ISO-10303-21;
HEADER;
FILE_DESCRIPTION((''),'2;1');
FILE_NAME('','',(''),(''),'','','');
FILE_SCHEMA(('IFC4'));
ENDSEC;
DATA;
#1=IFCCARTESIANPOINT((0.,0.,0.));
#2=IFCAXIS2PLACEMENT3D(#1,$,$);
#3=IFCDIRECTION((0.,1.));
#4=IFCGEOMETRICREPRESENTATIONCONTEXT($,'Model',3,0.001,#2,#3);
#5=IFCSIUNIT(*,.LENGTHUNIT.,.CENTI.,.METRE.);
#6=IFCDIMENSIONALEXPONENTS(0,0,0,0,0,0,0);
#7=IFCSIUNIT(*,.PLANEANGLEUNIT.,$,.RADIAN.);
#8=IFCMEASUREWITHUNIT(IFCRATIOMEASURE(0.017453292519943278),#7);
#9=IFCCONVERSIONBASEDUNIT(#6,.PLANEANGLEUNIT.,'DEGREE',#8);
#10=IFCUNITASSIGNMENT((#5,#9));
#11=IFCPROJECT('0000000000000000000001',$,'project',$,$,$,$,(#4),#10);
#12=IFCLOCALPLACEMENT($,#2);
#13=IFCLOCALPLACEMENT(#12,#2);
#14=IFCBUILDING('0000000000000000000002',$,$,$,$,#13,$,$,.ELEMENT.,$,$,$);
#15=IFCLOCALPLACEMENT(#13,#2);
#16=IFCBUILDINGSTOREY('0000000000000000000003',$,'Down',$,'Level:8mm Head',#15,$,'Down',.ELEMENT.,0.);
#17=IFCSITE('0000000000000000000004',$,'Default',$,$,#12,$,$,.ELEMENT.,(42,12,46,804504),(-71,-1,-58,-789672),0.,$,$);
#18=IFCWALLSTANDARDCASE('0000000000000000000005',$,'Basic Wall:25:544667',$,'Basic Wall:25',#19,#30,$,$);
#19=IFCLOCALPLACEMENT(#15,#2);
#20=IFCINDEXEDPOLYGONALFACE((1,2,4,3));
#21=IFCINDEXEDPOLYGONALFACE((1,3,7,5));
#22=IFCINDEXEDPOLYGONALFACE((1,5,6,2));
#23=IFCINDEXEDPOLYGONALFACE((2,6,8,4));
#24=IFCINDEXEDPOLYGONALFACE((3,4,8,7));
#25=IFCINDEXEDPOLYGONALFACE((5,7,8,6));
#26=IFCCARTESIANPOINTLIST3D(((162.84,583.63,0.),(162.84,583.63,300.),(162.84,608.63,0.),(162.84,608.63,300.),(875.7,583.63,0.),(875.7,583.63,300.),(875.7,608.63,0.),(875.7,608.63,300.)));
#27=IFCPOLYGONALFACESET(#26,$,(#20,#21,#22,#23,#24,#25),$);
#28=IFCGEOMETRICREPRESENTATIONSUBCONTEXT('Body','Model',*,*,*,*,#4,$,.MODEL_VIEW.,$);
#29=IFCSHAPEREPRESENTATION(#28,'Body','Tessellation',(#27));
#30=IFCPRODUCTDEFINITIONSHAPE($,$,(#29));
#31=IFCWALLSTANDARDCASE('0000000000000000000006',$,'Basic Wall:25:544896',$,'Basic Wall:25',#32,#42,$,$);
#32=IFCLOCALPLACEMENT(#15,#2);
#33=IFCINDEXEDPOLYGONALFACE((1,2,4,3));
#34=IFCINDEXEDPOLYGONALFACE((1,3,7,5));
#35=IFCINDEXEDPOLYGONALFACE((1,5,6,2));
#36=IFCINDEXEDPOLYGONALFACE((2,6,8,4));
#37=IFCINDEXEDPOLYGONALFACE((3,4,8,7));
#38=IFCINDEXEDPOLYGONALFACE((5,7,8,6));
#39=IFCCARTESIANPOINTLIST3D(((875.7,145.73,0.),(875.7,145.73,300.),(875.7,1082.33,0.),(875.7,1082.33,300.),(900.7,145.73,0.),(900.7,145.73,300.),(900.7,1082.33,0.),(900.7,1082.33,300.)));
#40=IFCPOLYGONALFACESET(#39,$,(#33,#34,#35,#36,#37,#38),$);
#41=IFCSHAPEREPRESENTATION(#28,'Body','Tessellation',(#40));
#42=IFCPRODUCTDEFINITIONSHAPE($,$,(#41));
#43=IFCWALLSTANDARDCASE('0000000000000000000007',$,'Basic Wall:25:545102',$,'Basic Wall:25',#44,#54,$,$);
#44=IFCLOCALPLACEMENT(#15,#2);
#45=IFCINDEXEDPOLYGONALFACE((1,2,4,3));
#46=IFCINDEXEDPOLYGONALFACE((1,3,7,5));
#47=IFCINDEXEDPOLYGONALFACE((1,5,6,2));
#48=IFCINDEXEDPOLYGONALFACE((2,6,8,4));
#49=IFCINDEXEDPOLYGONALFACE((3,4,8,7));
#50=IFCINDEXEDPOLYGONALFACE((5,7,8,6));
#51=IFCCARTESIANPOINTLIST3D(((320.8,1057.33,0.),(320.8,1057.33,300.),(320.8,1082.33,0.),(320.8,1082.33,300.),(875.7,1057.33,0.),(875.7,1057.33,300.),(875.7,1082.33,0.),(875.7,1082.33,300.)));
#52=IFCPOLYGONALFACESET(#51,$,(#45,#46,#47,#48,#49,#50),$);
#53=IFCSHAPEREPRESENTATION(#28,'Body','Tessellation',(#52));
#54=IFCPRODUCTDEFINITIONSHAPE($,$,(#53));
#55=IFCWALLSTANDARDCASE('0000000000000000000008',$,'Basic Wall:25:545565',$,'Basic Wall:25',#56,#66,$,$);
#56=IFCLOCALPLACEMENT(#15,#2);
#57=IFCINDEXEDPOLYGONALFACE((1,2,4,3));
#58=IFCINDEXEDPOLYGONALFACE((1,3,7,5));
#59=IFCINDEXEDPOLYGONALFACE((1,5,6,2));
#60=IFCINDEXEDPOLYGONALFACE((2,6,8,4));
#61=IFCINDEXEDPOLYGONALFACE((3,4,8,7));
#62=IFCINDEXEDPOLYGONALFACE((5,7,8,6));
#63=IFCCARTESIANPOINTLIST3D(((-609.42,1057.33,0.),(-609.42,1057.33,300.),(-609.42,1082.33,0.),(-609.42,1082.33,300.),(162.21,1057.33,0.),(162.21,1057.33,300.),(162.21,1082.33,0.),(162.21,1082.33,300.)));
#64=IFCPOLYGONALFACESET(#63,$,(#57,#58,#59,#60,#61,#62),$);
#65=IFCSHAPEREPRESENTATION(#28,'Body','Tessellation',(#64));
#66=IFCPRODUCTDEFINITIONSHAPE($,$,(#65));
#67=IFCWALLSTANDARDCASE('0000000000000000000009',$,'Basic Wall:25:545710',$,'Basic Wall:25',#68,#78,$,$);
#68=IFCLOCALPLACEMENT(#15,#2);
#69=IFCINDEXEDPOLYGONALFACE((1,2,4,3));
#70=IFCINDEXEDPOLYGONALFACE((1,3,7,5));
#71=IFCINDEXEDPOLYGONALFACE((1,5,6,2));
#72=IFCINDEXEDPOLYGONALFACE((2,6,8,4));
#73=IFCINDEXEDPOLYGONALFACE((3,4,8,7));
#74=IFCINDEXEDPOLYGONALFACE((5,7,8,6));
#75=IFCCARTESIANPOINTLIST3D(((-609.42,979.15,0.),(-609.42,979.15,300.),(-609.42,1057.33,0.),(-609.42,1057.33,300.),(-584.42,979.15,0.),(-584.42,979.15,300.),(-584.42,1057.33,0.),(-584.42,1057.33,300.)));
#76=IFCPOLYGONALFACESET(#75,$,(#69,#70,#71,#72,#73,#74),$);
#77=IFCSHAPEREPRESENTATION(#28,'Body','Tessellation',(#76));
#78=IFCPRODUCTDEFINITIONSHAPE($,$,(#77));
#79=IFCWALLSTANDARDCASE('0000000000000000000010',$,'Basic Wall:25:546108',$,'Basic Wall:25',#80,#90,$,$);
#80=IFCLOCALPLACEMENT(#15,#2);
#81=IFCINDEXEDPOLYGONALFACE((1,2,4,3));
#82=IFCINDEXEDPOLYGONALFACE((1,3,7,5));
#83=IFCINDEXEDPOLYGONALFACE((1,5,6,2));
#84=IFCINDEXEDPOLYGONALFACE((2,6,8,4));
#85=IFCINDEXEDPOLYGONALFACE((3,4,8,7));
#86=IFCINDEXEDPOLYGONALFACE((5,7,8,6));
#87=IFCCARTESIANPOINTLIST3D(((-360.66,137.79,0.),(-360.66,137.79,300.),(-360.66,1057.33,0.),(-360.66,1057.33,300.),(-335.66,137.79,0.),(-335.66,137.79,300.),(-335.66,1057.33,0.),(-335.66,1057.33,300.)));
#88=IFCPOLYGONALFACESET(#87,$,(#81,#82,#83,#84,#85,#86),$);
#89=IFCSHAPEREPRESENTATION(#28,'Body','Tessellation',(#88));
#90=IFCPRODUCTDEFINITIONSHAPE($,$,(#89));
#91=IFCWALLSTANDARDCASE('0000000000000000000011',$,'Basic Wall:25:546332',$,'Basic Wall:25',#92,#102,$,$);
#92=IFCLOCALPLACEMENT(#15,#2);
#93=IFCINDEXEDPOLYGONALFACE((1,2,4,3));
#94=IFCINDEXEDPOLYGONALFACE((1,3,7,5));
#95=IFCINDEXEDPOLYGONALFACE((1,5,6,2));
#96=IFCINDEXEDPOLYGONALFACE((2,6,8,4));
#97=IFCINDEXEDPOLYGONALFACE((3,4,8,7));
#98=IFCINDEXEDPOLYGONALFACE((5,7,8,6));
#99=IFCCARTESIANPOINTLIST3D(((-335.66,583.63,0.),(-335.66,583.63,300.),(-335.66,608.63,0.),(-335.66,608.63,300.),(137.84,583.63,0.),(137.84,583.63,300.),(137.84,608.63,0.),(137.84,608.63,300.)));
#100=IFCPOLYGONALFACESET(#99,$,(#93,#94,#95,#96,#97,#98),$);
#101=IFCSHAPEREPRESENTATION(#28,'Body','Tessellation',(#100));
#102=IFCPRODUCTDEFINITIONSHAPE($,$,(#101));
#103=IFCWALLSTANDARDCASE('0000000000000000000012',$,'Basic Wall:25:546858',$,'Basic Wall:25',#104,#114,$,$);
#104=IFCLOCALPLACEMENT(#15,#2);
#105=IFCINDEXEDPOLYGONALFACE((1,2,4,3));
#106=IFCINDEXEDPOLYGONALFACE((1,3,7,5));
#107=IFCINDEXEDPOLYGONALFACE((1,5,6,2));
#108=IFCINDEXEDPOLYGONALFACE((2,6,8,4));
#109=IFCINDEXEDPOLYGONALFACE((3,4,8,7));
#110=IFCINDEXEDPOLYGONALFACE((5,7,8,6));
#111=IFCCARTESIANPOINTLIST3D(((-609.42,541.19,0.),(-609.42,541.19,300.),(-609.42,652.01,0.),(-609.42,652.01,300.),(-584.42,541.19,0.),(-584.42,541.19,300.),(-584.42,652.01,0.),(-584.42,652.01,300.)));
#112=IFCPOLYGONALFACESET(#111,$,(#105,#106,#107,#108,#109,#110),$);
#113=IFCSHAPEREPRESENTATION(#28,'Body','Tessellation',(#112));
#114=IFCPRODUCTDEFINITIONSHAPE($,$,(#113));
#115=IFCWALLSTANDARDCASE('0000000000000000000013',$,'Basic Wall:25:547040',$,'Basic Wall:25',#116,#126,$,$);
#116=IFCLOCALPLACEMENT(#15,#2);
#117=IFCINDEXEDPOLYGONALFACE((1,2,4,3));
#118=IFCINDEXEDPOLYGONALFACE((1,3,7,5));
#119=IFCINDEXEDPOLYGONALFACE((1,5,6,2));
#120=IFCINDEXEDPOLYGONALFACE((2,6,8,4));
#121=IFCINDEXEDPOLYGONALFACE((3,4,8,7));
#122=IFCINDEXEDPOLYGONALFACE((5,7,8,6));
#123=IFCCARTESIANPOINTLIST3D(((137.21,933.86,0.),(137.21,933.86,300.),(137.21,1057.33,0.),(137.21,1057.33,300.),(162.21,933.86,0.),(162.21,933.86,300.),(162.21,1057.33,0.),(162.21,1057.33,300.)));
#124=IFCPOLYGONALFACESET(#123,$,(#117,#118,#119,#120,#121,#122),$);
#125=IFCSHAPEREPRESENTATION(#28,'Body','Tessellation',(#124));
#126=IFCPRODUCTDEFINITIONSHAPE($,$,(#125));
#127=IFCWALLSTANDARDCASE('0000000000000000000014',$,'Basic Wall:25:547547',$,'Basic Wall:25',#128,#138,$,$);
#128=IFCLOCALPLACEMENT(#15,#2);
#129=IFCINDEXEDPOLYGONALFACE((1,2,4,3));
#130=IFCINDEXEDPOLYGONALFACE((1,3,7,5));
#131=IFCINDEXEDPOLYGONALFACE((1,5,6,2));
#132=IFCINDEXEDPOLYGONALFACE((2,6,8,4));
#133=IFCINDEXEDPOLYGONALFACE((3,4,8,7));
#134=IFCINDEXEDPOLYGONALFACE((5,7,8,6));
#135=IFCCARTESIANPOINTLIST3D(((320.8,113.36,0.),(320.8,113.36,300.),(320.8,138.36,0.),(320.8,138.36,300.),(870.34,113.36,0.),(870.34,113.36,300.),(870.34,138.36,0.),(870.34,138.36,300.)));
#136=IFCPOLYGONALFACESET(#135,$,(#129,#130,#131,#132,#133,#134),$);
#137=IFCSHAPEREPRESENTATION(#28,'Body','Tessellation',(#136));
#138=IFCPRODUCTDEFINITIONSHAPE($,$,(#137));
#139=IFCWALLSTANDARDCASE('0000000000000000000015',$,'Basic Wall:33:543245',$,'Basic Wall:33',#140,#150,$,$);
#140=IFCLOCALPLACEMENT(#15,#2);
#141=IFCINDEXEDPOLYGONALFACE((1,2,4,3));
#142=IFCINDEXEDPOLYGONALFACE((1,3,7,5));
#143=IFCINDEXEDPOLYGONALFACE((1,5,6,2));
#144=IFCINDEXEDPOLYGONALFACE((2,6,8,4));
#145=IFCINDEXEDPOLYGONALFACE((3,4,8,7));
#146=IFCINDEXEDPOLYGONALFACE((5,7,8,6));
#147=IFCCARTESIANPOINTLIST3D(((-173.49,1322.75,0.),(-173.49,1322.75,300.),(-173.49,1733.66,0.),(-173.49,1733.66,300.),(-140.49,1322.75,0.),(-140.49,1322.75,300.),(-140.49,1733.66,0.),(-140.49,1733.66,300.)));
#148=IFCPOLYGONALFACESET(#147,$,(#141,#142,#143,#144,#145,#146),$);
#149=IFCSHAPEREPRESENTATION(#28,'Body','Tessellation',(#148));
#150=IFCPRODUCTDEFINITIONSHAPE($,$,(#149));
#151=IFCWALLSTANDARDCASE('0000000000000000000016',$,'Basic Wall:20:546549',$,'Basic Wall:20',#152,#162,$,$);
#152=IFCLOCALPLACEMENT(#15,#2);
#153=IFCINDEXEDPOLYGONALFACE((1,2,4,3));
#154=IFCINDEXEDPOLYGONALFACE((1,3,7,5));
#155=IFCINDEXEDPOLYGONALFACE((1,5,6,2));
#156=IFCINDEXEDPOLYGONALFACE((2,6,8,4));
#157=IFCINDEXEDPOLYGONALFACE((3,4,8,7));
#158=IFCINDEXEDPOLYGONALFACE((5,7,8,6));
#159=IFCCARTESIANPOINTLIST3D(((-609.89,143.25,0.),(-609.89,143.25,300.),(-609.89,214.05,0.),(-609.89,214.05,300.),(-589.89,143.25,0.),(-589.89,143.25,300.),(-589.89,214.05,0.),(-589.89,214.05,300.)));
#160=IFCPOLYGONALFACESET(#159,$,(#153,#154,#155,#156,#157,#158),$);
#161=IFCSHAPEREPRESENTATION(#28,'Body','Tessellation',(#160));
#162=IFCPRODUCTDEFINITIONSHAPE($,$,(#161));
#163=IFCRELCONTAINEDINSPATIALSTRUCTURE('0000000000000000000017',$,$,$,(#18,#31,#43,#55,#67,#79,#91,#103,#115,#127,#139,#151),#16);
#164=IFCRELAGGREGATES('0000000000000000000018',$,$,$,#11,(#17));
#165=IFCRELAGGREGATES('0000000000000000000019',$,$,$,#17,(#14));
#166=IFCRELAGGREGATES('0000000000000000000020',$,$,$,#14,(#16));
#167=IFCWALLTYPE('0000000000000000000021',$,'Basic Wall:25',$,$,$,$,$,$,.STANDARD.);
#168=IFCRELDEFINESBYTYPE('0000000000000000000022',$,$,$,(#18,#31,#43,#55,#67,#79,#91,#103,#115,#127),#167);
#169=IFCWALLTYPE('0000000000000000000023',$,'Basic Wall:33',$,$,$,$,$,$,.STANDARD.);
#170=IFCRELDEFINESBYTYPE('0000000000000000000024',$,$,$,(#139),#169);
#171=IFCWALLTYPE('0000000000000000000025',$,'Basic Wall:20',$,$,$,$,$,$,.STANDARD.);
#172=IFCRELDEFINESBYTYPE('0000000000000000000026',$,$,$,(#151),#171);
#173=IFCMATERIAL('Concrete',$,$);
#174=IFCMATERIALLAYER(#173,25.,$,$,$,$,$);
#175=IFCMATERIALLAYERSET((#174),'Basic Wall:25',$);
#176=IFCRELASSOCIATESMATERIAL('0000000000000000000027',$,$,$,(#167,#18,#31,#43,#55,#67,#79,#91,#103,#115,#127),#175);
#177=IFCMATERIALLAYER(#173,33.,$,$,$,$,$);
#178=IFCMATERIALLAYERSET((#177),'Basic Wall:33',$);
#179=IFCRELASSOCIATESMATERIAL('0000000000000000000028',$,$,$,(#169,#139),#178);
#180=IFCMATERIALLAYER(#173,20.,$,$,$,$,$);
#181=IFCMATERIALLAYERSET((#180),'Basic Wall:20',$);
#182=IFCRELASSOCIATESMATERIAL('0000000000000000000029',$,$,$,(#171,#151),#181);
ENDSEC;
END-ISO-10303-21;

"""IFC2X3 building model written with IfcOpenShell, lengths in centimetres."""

from ifc_helpers import new_model, entity, si_unit, converted_unit, direction, frame, frame_2d, origin, place, context, subcontext, project, spatial, polyline, rectangle, extrude, clip, bounded_halfspace, material, layer, layer_set, layer_usage, type_object, element, save


model = new_model("IFC2X3")

# Units and contexts
model_context = context("Model", 3, precision=0.001, world=origin(), true_north=direction((0.0, 1.0)))
body_context = subcontext(model_context, "Body", "Model", "MODEL_VIEW")
ifc_project = project(units=[si_unit("LENGTHUNIT", "METRE", prefix="CENTI"), converted_unit("PLANEANGLEUNIT", "DEGREE", entity("IfcRatioMeasure", 0.017453292519943278), si_unit("PLANEANGLEUNIT", "RADIAN"), dimensions=[0, 0, 0, 0, 0, 0, 0])], contexts=[model_context])

# Site, building, storey
site_placement = place(None, origin())
site = spatial("IfcSite", under=ifc_project, at=site_placement, Name="Default", CompositionType="ELEMENT", RefLatitude=(42, 12, 46, 804504), RefLongitude=(-71, -1, -58, -789672), RefElevation=0.0)
building_placement = place(site_placement, origin())
building = spatial("IfcBuilding", under=site, at=building_placement, CompositionType="ELEMENT")
storey_placement = place(building_placement, origin())
storey = spatial("IfcBuildingStorey", under=building, at=storey_placement, Name="Down", ObjectType="Level:8mm Head", LongName="Down", CompositionType="ELEMENT", Elevation=0.0)

# Shared definitions
ifc_material = material(Name="Concrete")

# Walls
ifc_layer_1 = layer(ifc_material, 25.0)
ifc_layer_set_1 = layer_set([ifc_layer_1], Name="Basic Wall:25")
wall_type_1 = type_object("IfcWallType", Name="Basic Wall:25", PredefinedType="STANDARD", material=ifc_layer_set_1)
ifc_layer_usage_1 = layer_usage(ifc_layer_set_1, "AXIS2", "NEGATIVE", 12.5)
wall_1_placement = place(storey_placement, frame((162.84, 596.13, 0.0)))
element("IfcWallStandardCase", 1, at=wall_1_placement, inside=storey, type_object=wall_type_1, material=ifc_layer_usage_1, Name="Basic Wall:25:544667", ObjectType="Basic Wall:25", context=body_context, shape_type="SweptSolid", body=[
    extrude(rectangle(XDim=712.86, YDim=25.0, at=frame_2d((356.43, 0.0), x_axis=(-1.0, 0.0))), origin(), (0.0, 0.0, 1.0), 300.0),
])
ifc_layer_usage_2 = layer_usage(ifc_layer_set_1, "AXIS2", "POSITIVE", -12.5)
wall_2_placement = place(storey_placement, frame((888.2, 145.73, 0.0), z_axis=(0.0, 0.0, 1.0), x_axis=(0.0, 1.0, 0.0)))
element("IfcWallStandardCase", 2, at=wall_2_placement, inside=storey, type_object=wall_type_1, material=ifc_layer_usage_2, Name="Basic Wall:25:544896", ObjectType="Basic Wall:25", context=body_context, shape_type="SweptSolid", body=[
    extrude(rectangle(XDim=936.61, YDim=25.0, at=frame_2d((468.3, 0.0), x_axis=(-1.0, 0.0))), origin(), (0.0, 0.0, 1.0), 300.0),
])
ifc_layer_usage_3 = layer_usage(ifc_layer_set_1, "AXIS2", "POSITIVE", -12.5)
wall_3_placement = place(storey_placement, frame((875.7, 1069.83, 0.0), z_axis=(0.0, 0.0, 1.0), x_axis=(-1.0, 0.0, 0.0)))
element("IfcWallStandardCase", 3, at=wall_3_placement, inside=storey, type_object=wall_type_1, material=ifc_layer_usage_3, Name="Basic Wall:25:545102", ObjectType="Basic Wall:25", context=body_context, shape_type="SweptSolid", body=[
    extrude(rectangle(XDim=554.89, YDim=25.0, at=frame_2d((277.45, 0.0), x_axis=(-1.0, 0.0))), origin(), (0.0, 0.0, 1.0), 300.0),
])
ifc_layer_usage_4 = layer_usage(ifc_layer_set_1, "AXIS2", "POSITIVE", -12.5)
wall_4_placement = place(storey_placement, frame((162.21, 1069.83, 0.0), z_axis=(0.0, 0.0, 1.0), x_axis=(-1.0, 0.0, 0.0)))
element("IfcWallStandardCase", 4, at=wall_4_placement, inside=storey, type_object=wall_type_1, material=ifc_layer_usage_4, Name="Basic Wall:25:545565", ObjectType="Basic Wall:25", context=body_context, shape_type="SweptSolid", body=[
    extrude(rectangle(XDim=771.63, YDim=25.0, at=frame_2d((385.82, 0.0), x_axis=(-1.0, 0.0))), origin(), (0.0, 0.0, 1.0), 300.0),
])
ifc_layer_usage_5 = layer_usage(ifc_layer_set_1, "AXIS2", "POSITIVE", -12.5)
wall_5_placement = place(storey_placement, frame((-596.92, 1057.33, 0.0), z_axis=(0.0, 0.0, 1.0), x_axis=(0.0, -1.0, 0.0)))
element("IfcWallStandardCase", 5, at=wall_5_placement, inside=storey, type_object=wall_type_1, material=ifc_layer_usage_5, Name="Basic Wall:25:545710", ObjectType="Basic Wall:25", context=body_context, shape_type="SweptSolid", body=[
    extrude(rectangle(XDim=78.19, YDim=25.0, at=frame_2d((39.09, 0.0), x_axis=(-1.0, 0.0))), origin(), (0.0, 0.0, 1.0), 300.0),
])
ifc_layer_usage_6 = layer_usage(ifc_layer_set_1, "AXIS2", "NEGATIVE", 12.5)
wall_6_placement = place(storey_placement, frame((-348.16, 1057.33, 0.0), z_axis=(0.0, 0.0, 1.0), x_axis=(0.0, -1.0, 0.0)))
element("IfcWallStandardCase", 6, at=wall_6_placement, inside=storey, type_object=wall_type_1, material=ifc_layer_usage_6, Name="Basic Wall:25:546108", ObjectType="Basic Wall:25", context=body_context, shape_type="SweptSolid", body=[
    extrude(rectangle(XDim=919.54, YDim=25.0, at=frame_2d((459.77, 0.0), x_axis=(-1.0, 0.0))), origin(), (0.0, 0.0, 1.0), 300.0),
])
ifc_layer_usage_7 = layer_usage(ifc_layer_set_1, "AXIS2", "POSITIVE", -12.5)
wall_7_placement = place(storey_placement, frame((-335.66, 596.13, 0.0)))
element("IfcWallStandardCase", 7, at=wall_7_placement, inside=storey, type_object=wall_type_1, material=ifc_layer_usage_7, Name="Basic Wall:25:546332", ObjectType="Basic Wall:25", context=body_context, shape_type="SweptSolid", body=[
    extrude(rectangle(XDim=473.5, YDim=25.0, at=frame_2d((236.75, 0.0), x_axis=(-1.0, 0.0))), origin(), (0.0, 0.0, 1.0), 300.0),
])
ifc_layer_usage_8 = layer_usage(ifc_layer_set_1, "AXIS2", "NEGATIVE", 12.5)
wall_8_placement = place(storey_placement, frame((-596.92, 541.19, 0.0), z_axis=(0.0, 0.0, 1.0), x_axis=(0.0, 1.0, 0.0)))
element("IfcWallStandardCase", 8, at=wall_8_placement, inside=storey, type_object=wall_type_1, material=ifc_layer_usage_8, Name="Basic Wall:25:546858", ObjectType="Basic Wall:25", context=body_context, shape_type="SweptSolid", body=[
    extrude(rectangle(XDim=110.81, YDim=25.0, at=frame_2d((55.41, 0.0), x_axis=(-1.0, 0.0))), origin(), (0.0, 0.0, 1.0), 300.0),
])
ifc_layer_usage_9 = layer_usage(ifc_layer_set_1, "AXIS2", "NEGATIVE", 12.5)
wall_9_placement = place(storey_placement, frame((149.71, 1057.33, 0.0), z_axis=(0.0, 0.0, 1.0), x_axis=(0.0, -1.0, 0.0)))
element("IfcWallStandardCase", 9, at=wall_9_placement, inside=storey, type_object=wall_type_1, material=ifc_layer_usage_9, Name="Basic Wall:25:547040", ObjectType="Basic Wall:25", context=body_context, shape_type="SweptSolid", body=[
    extrude(rectangle(XDim=123.47, YDim=25.0, at=frame_2d((61.74, 0.0), x_axis=(-1.0, 0.0))), origin(), (0.0, 0.0, 1.0), 300.0),
])
ifc_layer_usage_10 = layer_usage(ifc_layer_set_1, "AXIS2", "POSITIVE", -12.5)
wall_10_placement = place(storey_placement, frame((320.8, 125.86, 0.0)))
element("IfcWallStandardCase", 10, at=wall_10_placement, inside=storey, type_object=wall_type_1, material=ifc_layer_usage_10, Name="Basic Wall:25:547547", ObjectType="Basic Wall:25", context=body_context, shape_type="Clipping", body=[
    clip(extrude(rectangle(XDim=549.53, YDim=25.0, at=frame_2d((274.77, 0.0), x_axis=(-1.0, 0.0))), origin(), (0.0, 0.0, 1.0), 300.0), bounded_halfspace(frame((549.53, -12.5, 300.0), z_axis=(-1.0, 0.0, 0.0), x_axis=(0.0, 0.0, -1.0)), True, frame((549.53, -12.5, 300.0), z_axis=(-1.0, 0.0, 0.0), x_axis=(0.0, 0.0, -1.0)), polyline([(0.0, 0.0), (0.0, -25.0), (300.0, -25.0), (300.0, 0.0), (23.0, 0.0), (0.0, 0.0)]))),
])
ifc_layer_2 = layer(ifc_material, 33.0)
ifc_layer_set_2 = layer_set([ifc_layer_2], Name="Basic Wall:33")
ifc_layer_usage_11 = layer_usage(ifc_layer_set_2, "AXIS2", "NEGATIVE", 16.5)
wall_type_2 = type_object("IfcWallType", Name="Basic Wall:33", PredefinedType="STANDARD", material=ifc_layer_set_2)
wall_11_placement = place(storey_placement, frame((-156.99, 1322.75, 0.0), z_axis=(0.0, 0.0, 1.0), x_axis=(0.0, 1.0, 0.0)))
element("IfcWallStandardCase", 11, at=wall_11_placement, inside=storey, type_object=wall_type_2, material=ifc_layer_usage_11, Name="Basic Wall:33:543245", ObjectType="Basic Wall:33", context=body_context, shape_type="SweptSolid", body=[
    extrude(rectangle(XDim=410.91, YDim=33.0, at=frame_2d((205.46, 0.0), x_axis=(-1.0, 0.0))), origin(), (0.0, 0.0, 1.0), 300.0),
])
ifc_layer_3 = layer(ifc_material, 20.0)
ifc_layer_set_3 = layer_set([ifc_layer_3], Name="Basic Wall:20")
ifc_layer_usage_12 = layer_usage(ifc_layer_set_3, "AXIS2", "NEGATIVE", 10.0)
wall_type_3 = type_object("IfcWallType", Name="Basic Wall:20", PredefinedType="STANDARD", material=ifc_layer_set_3)
wall_12_placement = place(storey_placement, frame((-599.89, 143.25, 0.0), z_axis=(0.0, 0.0, 1.0), x_axis=(0.0, 1.0, 0.0)))
element("IfcWallStandardCase", 12, at=wall_12_placement, inside=storey, type_object=wall_type_3, material=ifc_layer_usage_12, Name="Basic Wall:20:546549", ObjectType="Basic Wall:20", context=body_context, shape_type="SweptSolid", body=[
    extrude(rectangle(XDim=70.8, YDim=20.0, at=frame_2d((35.4, 0.0), x_axis=(-1.0, 0.0))), origin(), (0.0, 0.0, 1.0), 300.0),
])

save(model, "model.ifc")
